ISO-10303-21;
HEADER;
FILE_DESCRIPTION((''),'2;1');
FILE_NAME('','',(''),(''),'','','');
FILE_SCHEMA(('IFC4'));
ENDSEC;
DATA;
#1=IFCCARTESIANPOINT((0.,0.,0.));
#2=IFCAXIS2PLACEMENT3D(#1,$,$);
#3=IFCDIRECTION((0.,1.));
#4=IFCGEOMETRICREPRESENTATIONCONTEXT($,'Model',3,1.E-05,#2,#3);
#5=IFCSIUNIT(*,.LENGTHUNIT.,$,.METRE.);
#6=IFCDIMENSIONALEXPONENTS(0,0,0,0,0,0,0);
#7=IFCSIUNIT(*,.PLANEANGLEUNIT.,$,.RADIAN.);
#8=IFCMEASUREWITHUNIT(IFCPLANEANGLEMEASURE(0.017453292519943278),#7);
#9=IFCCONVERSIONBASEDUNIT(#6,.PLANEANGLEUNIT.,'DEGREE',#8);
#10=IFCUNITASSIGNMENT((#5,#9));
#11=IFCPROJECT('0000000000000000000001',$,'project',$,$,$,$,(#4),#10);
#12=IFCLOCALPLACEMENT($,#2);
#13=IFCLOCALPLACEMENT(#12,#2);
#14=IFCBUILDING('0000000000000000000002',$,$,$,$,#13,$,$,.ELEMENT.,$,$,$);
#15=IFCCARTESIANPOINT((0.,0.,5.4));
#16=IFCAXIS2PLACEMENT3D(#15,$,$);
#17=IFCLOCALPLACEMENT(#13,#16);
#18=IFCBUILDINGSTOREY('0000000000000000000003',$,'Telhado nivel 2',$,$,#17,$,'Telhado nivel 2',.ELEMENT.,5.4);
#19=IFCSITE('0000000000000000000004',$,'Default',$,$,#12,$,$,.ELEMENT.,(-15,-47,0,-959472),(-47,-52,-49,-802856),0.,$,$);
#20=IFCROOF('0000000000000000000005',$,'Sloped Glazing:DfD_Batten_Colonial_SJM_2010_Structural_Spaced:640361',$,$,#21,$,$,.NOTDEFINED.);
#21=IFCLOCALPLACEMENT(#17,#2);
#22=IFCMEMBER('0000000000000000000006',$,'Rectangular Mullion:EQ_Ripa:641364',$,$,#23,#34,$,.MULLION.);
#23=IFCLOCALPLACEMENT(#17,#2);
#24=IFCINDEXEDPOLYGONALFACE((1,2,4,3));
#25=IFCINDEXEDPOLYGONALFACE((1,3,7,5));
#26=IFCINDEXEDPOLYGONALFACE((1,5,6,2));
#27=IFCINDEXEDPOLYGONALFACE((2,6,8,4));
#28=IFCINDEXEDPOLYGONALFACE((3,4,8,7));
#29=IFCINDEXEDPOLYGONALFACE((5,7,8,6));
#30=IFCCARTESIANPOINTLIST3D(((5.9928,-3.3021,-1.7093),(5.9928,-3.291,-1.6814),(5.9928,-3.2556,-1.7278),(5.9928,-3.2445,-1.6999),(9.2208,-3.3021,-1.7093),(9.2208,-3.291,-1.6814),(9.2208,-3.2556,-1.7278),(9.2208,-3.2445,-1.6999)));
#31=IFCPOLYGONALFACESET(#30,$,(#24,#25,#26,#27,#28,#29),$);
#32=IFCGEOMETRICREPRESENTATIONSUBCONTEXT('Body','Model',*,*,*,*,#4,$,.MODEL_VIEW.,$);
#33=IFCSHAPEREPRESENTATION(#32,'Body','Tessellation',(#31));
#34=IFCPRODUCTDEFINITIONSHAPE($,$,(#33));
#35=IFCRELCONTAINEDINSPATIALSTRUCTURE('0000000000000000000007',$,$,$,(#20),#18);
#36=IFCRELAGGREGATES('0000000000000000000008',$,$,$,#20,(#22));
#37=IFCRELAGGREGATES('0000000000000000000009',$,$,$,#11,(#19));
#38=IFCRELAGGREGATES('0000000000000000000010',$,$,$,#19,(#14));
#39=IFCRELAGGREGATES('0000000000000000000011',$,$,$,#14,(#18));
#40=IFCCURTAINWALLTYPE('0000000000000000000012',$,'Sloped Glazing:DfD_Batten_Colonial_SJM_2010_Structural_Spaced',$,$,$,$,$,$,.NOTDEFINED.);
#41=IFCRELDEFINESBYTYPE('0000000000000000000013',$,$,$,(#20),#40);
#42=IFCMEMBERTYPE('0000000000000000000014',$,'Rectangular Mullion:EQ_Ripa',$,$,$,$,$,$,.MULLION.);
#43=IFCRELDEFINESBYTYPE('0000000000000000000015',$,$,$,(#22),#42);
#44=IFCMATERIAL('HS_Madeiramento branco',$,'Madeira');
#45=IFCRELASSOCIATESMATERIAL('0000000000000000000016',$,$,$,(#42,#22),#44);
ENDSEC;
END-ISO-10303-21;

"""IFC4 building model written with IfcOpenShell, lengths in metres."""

from ifc_helpers import new_model, entity, si_unit, converted_unit, direction, frame, origin, place, context, subcontext, project, spatial, indexed_curve, outline, extrude, source, transform, mapped, material, type_object, type_shapes, element, aggregate, save


model = new_model("IFC4")

# Units and contexts
model_context = context("Model", 3, precision=1e-05, world=origin(), true_north=direction((0.0, 1.0)))
body_context = subcontext(model_context, "Body", "Model", "MODEL_VIEW")
ifc_project = project(units=[si_unit("LENGTHUNIT", "METRE"), converted_unit("PLANEANGLEUNIT", "DEGREE", entity("IfcPlaneAngleMeasure", 0.017453292519943278), si_unit("PLANEANGLEUNIT", "RADIAN"), dimensions=[0, 0, 0, 0, 0, 0, 0])], contexts=[model_context])

# Site, building, storey
site_placement = place(None, origin())
site = spatial("IfcSite", under=ifc_project, at=site_placement, Name="Default", CompositionType="ELEMENT", RefLatitude=(-15, -47, 0, -959472), RefLongitude=(-47, -52, -49, -802856), RefElevation=0.0)
building_placement = place(site_placement, origin())
building = spatial("IfcBuilding", under=site, at=building_placement, CompositionType="ELEMENT")
storey_placement = place(building_placement, frame((0.0, 0.0, 5.4)))
storey = spatial("IfcBuildingStorey", under=building, at=storey_placement, Name="Telhado nivel 2", LongName="Telhado nivel 2", CompositionType="ELEMENT", Elevation=5.4)

# Roof, member
ifc_material = material(Name="HS_Madeiramento branco", Category="Madeira")
curtain_wall_type_1 = type_object("IfcCurtainWallType", Name="Sloped Glazing:DfD_Batten_Colonial_SJM_2010_Structural_Spaced", PredefinedType="NOTDEFINED")
roof_1_placement = place(storey_placement, frame((0.0, 0.0, -5.4)))
roof_1 = element("IfcRoof", 1, at=roof_1_placement, inside=storey, type_object=curtain_wall_type_1, Name="Sloped Glazing:DfD_Batten_Colonial_SJM_2010_Structural_Spaced:640361", PredefinedType="NOTDEFINED")
member_type_1 = type_object("IfcMemberType", Name="Rectangular Mullion:EQ_Ripa", PredefinedType="MULLION", material=ifc_material)
shared_shape_1 = source(origin(), body_context, "Body", "SweptSolid", [
    extrude(outline(indexed_curve([(-0.025, -0.015), (0.025, -0.015), (0.025, 0.015), (-0.025, 0.015), (-0.025, -0.015)], self_intersect=False)), frame((0.0, 0.0, -3.228), z_axis=(0.0, 0.0, 1.0), x_axis=(-1.0, 0.0, 0.0)), (0.0, 0.0, 1.0), 3.228),
])
type_shapes(member_type_1, [shared_shape_1])
member_1_placement = place(roof_1_placement, frame((9.2208, -3.2733, 3.6954), z_axis=(1.0, 0.0, 0.0), x_axis=(0.0, -0.928874, 0.370395)))
member_1 = element("IfcMember", 2, at=member_1_placement, type_object=member_type_1, material=ifc_material, Name="Rectangular Mullion:EQ_Ripa:641364", PredefinedType="MULLION", context=body_context, shape_type="MappedRepresentation", body=[
    mapped(shared_shape_1, transform((0.0, 0.0, 0.0), scale=1.0)),
])
aggregate(roof_1, [member_1])

save(model, "model.ifc")
